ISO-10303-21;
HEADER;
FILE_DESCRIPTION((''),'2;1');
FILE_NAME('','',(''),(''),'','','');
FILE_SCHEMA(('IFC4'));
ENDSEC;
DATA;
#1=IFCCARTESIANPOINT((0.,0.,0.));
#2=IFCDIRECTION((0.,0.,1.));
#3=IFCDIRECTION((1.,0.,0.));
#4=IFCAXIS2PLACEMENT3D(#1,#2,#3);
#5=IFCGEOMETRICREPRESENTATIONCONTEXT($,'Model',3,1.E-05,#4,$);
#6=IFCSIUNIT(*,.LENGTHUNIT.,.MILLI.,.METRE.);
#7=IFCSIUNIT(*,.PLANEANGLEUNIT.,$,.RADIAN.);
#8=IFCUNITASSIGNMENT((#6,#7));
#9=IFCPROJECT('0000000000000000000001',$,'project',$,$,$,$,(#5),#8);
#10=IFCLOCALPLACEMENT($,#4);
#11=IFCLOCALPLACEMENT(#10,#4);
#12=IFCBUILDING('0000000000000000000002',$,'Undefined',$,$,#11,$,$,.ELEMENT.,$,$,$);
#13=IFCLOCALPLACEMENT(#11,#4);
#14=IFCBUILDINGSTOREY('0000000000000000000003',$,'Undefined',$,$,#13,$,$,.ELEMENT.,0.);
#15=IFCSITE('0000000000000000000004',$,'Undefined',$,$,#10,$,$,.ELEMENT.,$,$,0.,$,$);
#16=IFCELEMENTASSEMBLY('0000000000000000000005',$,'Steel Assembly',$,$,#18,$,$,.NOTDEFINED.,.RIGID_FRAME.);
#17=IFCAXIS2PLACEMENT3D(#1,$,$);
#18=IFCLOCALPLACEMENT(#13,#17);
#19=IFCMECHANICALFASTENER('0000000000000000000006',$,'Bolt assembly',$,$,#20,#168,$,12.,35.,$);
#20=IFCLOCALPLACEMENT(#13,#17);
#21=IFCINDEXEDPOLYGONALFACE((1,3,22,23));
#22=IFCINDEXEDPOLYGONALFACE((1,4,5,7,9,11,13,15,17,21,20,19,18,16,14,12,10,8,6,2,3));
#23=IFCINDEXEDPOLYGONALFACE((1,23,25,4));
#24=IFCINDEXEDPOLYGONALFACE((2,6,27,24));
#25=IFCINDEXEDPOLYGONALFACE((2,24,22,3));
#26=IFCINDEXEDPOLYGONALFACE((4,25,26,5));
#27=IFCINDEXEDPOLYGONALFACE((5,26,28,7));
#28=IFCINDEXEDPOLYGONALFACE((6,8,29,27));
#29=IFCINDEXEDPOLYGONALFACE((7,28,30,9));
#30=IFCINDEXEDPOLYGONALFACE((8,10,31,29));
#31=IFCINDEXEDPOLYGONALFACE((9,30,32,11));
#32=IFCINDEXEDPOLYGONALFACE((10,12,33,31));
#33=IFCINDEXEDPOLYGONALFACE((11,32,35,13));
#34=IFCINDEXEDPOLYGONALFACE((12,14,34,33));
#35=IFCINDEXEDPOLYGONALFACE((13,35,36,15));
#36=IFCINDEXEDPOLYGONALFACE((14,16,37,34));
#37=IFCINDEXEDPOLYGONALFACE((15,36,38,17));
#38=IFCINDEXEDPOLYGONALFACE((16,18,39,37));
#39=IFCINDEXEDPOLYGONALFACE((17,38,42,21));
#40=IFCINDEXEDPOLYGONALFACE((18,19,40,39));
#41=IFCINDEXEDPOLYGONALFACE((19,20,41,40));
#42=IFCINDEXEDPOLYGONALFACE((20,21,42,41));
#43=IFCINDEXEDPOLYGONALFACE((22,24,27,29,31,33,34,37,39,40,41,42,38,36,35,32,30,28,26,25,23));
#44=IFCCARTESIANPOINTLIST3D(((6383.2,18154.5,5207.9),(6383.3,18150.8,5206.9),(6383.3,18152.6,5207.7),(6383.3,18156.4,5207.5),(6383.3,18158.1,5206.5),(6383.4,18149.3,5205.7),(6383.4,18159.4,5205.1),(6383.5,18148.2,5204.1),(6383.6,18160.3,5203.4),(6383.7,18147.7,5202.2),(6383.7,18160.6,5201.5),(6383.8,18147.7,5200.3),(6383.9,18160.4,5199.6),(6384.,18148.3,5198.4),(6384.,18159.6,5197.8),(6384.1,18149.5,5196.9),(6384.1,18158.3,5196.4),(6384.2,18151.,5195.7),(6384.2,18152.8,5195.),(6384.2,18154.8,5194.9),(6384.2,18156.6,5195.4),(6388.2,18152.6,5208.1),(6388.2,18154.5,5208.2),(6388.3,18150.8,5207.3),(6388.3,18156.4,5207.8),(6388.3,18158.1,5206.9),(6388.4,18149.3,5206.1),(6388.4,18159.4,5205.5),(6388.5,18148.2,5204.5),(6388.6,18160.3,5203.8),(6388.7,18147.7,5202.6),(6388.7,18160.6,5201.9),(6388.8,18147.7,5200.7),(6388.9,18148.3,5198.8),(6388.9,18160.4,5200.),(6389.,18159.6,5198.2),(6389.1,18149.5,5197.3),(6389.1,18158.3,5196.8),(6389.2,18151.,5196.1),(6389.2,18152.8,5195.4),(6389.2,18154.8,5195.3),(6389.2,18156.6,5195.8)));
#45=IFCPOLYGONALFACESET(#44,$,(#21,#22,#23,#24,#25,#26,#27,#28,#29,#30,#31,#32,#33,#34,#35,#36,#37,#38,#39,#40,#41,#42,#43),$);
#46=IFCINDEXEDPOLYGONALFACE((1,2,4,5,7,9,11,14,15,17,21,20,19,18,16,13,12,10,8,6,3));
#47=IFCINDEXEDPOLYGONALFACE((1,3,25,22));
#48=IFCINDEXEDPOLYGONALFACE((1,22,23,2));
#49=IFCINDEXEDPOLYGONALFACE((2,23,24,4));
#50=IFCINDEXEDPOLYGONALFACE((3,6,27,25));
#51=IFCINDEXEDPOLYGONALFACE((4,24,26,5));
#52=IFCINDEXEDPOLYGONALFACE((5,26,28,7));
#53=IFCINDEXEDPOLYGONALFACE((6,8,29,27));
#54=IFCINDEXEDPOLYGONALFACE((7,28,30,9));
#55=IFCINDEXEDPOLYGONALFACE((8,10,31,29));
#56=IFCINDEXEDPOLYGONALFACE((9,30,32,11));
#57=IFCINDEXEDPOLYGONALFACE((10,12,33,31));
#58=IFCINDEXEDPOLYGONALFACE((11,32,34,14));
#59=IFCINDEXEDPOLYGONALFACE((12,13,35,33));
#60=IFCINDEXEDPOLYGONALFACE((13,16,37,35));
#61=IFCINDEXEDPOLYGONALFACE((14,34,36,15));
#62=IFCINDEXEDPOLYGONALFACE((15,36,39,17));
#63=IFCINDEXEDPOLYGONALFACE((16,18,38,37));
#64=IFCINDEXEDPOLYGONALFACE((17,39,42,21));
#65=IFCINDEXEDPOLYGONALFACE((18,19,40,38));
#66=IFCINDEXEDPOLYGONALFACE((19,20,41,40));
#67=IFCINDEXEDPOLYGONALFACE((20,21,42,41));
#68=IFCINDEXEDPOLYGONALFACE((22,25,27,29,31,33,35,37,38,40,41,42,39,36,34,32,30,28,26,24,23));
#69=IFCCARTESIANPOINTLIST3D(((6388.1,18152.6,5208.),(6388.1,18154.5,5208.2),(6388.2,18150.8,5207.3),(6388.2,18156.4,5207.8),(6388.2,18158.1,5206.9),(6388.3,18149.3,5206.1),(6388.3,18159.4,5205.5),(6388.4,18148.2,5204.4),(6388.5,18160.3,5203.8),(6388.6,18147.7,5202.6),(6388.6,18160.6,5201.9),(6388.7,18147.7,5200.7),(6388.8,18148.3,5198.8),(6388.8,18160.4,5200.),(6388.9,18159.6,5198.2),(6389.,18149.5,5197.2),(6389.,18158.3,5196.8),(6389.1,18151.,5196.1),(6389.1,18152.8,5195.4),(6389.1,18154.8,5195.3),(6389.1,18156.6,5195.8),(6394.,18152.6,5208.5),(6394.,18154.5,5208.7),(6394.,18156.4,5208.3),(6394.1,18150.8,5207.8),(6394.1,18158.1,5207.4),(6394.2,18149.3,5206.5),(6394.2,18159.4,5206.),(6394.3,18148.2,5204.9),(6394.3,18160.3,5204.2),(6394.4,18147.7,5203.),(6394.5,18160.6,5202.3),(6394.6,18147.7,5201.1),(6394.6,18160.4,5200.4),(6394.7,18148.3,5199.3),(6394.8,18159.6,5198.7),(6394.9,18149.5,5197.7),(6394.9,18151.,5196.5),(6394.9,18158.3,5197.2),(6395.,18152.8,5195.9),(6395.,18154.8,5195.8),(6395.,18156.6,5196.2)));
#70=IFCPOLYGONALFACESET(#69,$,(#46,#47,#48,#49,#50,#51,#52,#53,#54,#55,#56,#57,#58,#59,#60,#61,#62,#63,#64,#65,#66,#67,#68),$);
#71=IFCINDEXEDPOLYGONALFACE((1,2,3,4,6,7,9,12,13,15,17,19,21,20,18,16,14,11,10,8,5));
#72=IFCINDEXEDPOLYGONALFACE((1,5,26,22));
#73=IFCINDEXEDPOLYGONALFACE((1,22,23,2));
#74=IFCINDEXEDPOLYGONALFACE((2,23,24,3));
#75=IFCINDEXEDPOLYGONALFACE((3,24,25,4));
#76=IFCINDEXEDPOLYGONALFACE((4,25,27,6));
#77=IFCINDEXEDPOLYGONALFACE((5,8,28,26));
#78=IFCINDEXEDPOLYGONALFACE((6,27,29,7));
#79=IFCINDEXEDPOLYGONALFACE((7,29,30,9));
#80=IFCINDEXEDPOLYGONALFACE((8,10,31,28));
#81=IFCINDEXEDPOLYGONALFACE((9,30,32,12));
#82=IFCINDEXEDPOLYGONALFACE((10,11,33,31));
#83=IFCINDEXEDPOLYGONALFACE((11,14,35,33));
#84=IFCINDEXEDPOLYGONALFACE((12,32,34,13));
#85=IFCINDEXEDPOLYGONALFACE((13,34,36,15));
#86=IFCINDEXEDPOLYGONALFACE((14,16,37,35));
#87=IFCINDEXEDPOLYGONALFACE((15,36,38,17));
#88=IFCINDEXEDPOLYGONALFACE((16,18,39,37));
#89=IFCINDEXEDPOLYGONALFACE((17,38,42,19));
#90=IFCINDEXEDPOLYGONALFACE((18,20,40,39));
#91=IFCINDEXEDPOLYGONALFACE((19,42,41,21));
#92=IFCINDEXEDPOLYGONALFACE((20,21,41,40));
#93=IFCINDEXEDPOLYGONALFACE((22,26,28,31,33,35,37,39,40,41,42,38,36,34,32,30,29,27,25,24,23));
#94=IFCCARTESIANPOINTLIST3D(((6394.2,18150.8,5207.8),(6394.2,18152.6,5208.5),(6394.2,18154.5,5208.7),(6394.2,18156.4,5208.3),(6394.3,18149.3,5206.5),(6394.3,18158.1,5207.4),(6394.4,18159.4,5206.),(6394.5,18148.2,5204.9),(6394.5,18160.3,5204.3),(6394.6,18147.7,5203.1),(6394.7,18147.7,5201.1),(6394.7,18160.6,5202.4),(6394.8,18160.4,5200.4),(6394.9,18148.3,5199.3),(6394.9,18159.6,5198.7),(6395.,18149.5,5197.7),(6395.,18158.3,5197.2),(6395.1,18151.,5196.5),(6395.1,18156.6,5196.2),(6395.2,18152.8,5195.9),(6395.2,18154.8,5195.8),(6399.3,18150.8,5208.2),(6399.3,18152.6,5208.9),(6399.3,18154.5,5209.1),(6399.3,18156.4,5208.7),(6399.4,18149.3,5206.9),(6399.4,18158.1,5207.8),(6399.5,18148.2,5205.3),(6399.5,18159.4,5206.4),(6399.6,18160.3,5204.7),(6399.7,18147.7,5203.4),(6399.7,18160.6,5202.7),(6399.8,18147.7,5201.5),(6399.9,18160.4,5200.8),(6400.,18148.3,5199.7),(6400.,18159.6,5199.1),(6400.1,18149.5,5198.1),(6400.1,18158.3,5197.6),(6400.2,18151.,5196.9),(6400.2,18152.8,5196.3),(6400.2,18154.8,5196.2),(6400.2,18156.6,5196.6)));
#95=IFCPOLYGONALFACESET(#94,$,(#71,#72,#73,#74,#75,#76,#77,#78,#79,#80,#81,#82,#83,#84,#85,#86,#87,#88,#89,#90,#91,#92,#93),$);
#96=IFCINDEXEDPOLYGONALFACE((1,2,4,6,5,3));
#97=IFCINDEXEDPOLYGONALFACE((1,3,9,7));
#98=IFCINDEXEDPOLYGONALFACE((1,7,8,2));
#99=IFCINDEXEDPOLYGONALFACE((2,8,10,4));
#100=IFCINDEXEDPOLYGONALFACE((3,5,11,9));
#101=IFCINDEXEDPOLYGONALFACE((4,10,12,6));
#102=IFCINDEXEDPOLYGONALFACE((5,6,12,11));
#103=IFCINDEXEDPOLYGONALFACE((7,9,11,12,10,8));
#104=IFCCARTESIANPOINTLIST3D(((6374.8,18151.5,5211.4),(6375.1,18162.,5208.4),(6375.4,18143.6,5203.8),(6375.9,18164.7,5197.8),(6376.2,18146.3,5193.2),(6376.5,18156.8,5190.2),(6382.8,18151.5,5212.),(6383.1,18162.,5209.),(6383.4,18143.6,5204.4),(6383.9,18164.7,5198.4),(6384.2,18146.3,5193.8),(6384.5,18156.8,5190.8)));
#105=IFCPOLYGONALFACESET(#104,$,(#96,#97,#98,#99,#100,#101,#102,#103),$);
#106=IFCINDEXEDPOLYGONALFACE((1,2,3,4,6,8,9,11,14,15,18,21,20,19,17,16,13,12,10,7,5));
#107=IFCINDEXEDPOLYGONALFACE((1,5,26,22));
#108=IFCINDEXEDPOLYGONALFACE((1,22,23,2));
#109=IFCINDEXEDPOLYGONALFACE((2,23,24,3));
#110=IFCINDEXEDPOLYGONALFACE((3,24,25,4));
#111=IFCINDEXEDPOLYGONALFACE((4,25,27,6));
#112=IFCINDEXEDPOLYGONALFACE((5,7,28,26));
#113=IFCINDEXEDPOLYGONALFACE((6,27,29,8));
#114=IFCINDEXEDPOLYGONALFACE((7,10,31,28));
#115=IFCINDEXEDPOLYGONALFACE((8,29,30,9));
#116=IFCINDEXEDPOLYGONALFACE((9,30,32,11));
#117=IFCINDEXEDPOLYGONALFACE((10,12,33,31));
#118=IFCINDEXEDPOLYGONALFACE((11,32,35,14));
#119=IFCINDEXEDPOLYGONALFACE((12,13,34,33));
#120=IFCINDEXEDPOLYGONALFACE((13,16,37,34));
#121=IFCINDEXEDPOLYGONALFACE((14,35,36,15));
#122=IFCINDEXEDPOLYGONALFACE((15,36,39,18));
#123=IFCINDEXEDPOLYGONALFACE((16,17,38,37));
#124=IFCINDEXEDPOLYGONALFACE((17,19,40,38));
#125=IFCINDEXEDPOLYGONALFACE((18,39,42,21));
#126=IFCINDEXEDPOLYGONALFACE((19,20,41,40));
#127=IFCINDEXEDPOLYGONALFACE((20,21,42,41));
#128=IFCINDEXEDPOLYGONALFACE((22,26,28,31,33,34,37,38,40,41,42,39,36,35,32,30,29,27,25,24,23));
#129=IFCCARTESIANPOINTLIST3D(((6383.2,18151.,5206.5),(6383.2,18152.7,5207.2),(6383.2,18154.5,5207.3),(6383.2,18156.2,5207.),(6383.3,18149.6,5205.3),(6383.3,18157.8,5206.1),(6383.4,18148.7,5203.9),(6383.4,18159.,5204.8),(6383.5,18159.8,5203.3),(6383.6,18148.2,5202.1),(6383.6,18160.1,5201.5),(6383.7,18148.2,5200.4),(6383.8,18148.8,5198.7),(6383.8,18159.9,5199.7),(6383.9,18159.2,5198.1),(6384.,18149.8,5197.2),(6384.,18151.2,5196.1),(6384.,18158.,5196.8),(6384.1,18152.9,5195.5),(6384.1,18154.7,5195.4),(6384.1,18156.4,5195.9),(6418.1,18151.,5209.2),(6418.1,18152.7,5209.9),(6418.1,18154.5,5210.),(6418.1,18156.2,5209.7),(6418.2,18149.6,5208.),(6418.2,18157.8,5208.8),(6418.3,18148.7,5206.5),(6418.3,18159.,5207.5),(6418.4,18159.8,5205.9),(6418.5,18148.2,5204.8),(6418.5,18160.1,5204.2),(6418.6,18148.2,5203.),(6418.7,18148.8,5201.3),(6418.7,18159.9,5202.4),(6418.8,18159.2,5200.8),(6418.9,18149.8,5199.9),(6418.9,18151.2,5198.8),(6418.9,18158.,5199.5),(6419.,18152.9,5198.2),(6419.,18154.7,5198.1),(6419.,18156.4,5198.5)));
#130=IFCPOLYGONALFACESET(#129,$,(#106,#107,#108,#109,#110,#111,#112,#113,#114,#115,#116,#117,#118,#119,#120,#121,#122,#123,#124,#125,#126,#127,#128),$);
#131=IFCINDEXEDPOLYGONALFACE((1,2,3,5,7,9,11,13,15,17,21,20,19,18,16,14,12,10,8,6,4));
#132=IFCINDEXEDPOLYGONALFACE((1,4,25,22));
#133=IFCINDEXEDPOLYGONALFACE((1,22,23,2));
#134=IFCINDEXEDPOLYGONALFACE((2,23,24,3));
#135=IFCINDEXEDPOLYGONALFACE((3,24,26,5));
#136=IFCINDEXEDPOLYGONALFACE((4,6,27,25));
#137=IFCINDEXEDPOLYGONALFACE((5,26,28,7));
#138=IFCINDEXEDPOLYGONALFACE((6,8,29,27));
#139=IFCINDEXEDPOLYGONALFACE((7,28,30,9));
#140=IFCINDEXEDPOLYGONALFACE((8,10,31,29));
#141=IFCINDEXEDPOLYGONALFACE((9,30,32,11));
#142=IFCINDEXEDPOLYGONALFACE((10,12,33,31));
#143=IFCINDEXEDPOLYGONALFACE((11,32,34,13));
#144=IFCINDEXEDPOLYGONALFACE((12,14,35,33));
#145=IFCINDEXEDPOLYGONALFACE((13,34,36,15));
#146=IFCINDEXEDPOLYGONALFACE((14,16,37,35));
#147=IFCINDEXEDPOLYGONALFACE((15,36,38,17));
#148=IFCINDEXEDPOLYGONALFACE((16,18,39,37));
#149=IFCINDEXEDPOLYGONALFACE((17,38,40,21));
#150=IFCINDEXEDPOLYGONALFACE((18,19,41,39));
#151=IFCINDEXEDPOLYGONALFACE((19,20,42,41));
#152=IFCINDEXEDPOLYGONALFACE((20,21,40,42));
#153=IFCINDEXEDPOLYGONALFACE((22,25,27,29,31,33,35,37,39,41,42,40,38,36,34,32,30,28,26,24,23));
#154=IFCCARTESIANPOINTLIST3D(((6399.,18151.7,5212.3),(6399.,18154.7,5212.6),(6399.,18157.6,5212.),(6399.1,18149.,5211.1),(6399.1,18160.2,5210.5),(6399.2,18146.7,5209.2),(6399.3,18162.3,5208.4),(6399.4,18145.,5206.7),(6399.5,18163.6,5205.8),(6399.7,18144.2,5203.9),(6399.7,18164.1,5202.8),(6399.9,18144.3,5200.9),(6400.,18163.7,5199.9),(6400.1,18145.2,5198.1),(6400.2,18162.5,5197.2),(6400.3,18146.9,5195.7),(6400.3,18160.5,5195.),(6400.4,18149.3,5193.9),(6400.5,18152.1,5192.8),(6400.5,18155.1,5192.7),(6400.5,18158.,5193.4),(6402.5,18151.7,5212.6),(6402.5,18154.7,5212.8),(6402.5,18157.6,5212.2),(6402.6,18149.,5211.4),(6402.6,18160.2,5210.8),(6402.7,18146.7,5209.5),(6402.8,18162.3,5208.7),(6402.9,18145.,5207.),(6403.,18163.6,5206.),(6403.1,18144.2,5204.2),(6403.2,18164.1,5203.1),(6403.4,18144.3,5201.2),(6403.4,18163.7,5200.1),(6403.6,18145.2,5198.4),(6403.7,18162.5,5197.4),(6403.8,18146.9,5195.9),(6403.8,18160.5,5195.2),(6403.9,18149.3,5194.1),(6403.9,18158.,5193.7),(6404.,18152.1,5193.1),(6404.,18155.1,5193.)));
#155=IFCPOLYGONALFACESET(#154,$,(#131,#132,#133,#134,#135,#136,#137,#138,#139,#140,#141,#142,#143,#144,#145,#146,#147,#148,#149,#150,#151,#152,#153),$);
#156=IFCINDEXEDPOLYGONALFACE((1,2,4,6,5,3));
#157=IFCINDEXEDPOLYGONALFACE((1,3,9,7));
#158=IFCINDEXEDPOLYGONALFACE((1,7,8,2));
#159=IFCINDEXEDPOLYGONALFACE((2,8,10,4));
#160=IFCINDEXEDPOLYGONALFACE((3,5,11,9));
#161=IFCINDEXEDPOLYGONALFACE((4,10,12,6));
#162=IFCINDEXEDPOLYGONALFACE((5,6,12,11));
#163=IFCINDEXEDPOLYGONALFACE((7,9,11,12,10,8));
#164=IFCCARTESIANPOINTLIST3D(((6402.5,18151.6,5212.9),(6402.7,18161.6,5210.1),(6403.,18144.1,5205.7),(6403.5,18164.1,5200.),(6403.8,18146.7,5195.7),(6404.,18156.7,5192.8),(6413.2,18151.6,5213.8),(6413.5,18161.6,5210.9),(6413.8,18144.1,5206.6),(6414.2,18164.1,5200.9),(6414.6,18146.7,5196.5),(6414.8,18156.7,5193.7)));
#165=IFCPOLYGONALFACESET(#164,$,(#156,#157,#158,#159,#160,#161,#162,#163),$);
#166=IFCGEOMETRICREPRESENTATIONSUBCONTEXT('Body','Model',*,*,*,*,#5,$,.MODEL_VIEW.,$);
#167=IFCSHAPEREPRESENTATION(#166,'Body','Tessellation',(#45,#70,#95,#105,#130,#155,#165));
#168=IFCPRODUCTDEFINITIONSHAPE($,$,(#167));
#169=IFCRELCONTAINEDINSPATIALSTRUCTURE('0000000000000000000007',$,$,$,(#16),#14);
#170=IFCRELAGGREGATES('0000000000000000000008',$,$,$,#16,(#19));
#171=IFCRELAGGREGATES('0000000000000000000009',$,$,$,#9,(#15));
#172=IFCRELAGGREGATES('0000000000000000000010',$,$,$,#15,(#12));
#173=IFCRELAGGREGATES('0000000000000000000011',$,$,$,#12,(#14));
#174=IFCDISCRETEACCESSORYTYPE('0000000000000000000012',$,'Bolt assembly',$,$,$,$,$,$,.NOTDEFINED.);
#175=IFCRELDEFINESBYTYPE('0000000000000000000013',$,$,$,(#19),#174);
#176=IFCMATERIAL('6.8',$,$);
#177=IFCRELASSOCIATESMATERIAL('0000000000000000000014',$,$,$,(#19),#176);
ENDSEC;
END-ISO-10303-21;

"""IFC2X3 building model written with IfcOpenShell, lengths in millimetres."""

from ifc_helpers import new_model, si_unit, frame, origin_with_axes, origin_2d_with_axis, place, context, subcontext, project, spatial, polyline, circle, outline, extrude, source, transform, mapped, material, type_object, element, aggregate, save


model = new_model("IFC2X3")

# Units and contexts
model_context = context("Model", 3, precision=1e-05, world=origin_with_axes())
body_context = subcontext(model_context, "Body", "Model", "MODEL_VIEW")
ifc_project = project(units=[si_unit("LENGTHUNIT", "METRE", prefix="MILLI"), si_unit("PLANEANGLEUNIT", "RADIAN")], contexts=[model_context])

# Site, building, storey
site_placement = place(None, origin_with_axes())
site = spatial("IfcSite", under=ifc_project, at=site_placement, Name="Undefined", CompositionType="ELEMENT", RefElevation=0.0)
building_placement = place(site_placement, origin_with_axes())
building = spatial("IfcBuilding", under=site, at=building_placement, Name="Undefined", CompositionType="ELEMENT")
storey_placement = place(building_placement, origin_with_axes())
storey = spatial("IfcBuildingStorey", under=building, at=storey_placement, Name="Undefined", CompositionType="ELEMENT", Elevation=0.0)

# Shared definitions
ifc_material_1 = material(Name="6.8")
discrete_accessory_type_1 = type_object("IfcDiscreteAccessoryType", Name="Bolt assembly")

# Element assembly, mechanical fastener
assembly_1_placement = place(storey_placement, origin_with_axes())
assembly_1 = element("IfcElementAssembly", 1, at=assembly_1_placement, inside=storey, Name="Steel Assembly", AssemblyPlace="NOTDEFINED", PredefinedType="RIGID_FRAME")
shared_shape_1 = source(origin_with_axes(), body_context, "Body", "SweptSolid", [
    extrude(circle(Radius=6.5, at=origin_2d_with_axis()), frame((0.0, 0.1, 0.0), z_axis=(0.0, 1.0, 0.0), x_axis=(1.0, 0.0, 0.0)), (0.0, 0.0, 1.0), 5.0),
    extrude(circle(Radius=6.5, at=origin_2d_with_axis()), frame((0.0, 5.0, 0.0), z_axis=(0.0, 1.0, 0.0), x_axis=(1.0, 0.0, 0.0)), (0.0, 0.0, 1.0), 5.9),
    extrude(circle(Radius=6.5, at=origin_2d_with_axis()), frame((0.0, 11.1, 0.0), z_axis=(0.0, 1.0, 0.0), x_axis=(1.0, 0.0, 0.0)), (0.0, 0.0, 1.0), 5.1),
    extrude(outline(polyline([(11.0, 0.0), (5.5, 9.5), (-5.5, 9.5), (-11.0, 0.0), (-5.5, -9.5), (5.5, -9.5), (11.0, 0.0)])), frame((0.0, -8.0, 0.0), z_axis=(0.0, 1.0, 0.0), x_axis=(1.0, 0.0, 0.0)), (0.0, 0.0, 1.0), 8.0),
    extrude(circle(Radius=6.0, at=origin_2d_with_axis()), frame((0.0, 0.0, 0.0), z_axis=(0.0, 1.0, 0.0), x_axis=(1.0, 0.0, 0.0)), (0.0, 0.0, 1.0), 35.0),
    extrude(circle(Radius=10.0, at=origin_2d_with_axis()), frame((0.0, 16.2, 0.0), z_axis=(0.0, 1.0, 0.0), x_axis=(1.0, 0.0, 0.0)), (0.0, 0.0, 1.0), 3.5),
    extrude(outline(polyline([(10.4, 0.0), (5.2, 9.0), (-5.2, 9.0), (-10.4, 0.0), (-5.2, -9.0), (5.2, -9.0), (10.4, 0.0)])), frame((0.0, 19.7, 0.0), z_axis=(0.0, 1.0, 0.0), x_axis=(1.0, 0.0, 0.0)), (0.0, 0.0, 1.0), 10.8),
])
mechanical_fastener_1_placement = place(assembly_1_placement, frame((6383.6, 18154.1, 5201.4), z_axis=(-0.055107, -0.695516, 0.716394), x_axis=(0.053344, -0.71851, -0.693468)))
mechanical_fastener_1 = element("IfcMechanicalFastener", 2, at=mechanical_fastener_1_placement, type_object=discrete_accessory_type_1, material=ifc_material_1, Name="Bolt assembly", NominalDiameter=12.0, NominalLength=35.0, context=body_context, shape_type="MappedRepresentation", body=[
    mapped(shared_shape_1, transform((0.0, 0.0, 0.0))),
])
aggregate(assembly_1, [mechanical_fastener_1])

save(model, "model.ifc")
